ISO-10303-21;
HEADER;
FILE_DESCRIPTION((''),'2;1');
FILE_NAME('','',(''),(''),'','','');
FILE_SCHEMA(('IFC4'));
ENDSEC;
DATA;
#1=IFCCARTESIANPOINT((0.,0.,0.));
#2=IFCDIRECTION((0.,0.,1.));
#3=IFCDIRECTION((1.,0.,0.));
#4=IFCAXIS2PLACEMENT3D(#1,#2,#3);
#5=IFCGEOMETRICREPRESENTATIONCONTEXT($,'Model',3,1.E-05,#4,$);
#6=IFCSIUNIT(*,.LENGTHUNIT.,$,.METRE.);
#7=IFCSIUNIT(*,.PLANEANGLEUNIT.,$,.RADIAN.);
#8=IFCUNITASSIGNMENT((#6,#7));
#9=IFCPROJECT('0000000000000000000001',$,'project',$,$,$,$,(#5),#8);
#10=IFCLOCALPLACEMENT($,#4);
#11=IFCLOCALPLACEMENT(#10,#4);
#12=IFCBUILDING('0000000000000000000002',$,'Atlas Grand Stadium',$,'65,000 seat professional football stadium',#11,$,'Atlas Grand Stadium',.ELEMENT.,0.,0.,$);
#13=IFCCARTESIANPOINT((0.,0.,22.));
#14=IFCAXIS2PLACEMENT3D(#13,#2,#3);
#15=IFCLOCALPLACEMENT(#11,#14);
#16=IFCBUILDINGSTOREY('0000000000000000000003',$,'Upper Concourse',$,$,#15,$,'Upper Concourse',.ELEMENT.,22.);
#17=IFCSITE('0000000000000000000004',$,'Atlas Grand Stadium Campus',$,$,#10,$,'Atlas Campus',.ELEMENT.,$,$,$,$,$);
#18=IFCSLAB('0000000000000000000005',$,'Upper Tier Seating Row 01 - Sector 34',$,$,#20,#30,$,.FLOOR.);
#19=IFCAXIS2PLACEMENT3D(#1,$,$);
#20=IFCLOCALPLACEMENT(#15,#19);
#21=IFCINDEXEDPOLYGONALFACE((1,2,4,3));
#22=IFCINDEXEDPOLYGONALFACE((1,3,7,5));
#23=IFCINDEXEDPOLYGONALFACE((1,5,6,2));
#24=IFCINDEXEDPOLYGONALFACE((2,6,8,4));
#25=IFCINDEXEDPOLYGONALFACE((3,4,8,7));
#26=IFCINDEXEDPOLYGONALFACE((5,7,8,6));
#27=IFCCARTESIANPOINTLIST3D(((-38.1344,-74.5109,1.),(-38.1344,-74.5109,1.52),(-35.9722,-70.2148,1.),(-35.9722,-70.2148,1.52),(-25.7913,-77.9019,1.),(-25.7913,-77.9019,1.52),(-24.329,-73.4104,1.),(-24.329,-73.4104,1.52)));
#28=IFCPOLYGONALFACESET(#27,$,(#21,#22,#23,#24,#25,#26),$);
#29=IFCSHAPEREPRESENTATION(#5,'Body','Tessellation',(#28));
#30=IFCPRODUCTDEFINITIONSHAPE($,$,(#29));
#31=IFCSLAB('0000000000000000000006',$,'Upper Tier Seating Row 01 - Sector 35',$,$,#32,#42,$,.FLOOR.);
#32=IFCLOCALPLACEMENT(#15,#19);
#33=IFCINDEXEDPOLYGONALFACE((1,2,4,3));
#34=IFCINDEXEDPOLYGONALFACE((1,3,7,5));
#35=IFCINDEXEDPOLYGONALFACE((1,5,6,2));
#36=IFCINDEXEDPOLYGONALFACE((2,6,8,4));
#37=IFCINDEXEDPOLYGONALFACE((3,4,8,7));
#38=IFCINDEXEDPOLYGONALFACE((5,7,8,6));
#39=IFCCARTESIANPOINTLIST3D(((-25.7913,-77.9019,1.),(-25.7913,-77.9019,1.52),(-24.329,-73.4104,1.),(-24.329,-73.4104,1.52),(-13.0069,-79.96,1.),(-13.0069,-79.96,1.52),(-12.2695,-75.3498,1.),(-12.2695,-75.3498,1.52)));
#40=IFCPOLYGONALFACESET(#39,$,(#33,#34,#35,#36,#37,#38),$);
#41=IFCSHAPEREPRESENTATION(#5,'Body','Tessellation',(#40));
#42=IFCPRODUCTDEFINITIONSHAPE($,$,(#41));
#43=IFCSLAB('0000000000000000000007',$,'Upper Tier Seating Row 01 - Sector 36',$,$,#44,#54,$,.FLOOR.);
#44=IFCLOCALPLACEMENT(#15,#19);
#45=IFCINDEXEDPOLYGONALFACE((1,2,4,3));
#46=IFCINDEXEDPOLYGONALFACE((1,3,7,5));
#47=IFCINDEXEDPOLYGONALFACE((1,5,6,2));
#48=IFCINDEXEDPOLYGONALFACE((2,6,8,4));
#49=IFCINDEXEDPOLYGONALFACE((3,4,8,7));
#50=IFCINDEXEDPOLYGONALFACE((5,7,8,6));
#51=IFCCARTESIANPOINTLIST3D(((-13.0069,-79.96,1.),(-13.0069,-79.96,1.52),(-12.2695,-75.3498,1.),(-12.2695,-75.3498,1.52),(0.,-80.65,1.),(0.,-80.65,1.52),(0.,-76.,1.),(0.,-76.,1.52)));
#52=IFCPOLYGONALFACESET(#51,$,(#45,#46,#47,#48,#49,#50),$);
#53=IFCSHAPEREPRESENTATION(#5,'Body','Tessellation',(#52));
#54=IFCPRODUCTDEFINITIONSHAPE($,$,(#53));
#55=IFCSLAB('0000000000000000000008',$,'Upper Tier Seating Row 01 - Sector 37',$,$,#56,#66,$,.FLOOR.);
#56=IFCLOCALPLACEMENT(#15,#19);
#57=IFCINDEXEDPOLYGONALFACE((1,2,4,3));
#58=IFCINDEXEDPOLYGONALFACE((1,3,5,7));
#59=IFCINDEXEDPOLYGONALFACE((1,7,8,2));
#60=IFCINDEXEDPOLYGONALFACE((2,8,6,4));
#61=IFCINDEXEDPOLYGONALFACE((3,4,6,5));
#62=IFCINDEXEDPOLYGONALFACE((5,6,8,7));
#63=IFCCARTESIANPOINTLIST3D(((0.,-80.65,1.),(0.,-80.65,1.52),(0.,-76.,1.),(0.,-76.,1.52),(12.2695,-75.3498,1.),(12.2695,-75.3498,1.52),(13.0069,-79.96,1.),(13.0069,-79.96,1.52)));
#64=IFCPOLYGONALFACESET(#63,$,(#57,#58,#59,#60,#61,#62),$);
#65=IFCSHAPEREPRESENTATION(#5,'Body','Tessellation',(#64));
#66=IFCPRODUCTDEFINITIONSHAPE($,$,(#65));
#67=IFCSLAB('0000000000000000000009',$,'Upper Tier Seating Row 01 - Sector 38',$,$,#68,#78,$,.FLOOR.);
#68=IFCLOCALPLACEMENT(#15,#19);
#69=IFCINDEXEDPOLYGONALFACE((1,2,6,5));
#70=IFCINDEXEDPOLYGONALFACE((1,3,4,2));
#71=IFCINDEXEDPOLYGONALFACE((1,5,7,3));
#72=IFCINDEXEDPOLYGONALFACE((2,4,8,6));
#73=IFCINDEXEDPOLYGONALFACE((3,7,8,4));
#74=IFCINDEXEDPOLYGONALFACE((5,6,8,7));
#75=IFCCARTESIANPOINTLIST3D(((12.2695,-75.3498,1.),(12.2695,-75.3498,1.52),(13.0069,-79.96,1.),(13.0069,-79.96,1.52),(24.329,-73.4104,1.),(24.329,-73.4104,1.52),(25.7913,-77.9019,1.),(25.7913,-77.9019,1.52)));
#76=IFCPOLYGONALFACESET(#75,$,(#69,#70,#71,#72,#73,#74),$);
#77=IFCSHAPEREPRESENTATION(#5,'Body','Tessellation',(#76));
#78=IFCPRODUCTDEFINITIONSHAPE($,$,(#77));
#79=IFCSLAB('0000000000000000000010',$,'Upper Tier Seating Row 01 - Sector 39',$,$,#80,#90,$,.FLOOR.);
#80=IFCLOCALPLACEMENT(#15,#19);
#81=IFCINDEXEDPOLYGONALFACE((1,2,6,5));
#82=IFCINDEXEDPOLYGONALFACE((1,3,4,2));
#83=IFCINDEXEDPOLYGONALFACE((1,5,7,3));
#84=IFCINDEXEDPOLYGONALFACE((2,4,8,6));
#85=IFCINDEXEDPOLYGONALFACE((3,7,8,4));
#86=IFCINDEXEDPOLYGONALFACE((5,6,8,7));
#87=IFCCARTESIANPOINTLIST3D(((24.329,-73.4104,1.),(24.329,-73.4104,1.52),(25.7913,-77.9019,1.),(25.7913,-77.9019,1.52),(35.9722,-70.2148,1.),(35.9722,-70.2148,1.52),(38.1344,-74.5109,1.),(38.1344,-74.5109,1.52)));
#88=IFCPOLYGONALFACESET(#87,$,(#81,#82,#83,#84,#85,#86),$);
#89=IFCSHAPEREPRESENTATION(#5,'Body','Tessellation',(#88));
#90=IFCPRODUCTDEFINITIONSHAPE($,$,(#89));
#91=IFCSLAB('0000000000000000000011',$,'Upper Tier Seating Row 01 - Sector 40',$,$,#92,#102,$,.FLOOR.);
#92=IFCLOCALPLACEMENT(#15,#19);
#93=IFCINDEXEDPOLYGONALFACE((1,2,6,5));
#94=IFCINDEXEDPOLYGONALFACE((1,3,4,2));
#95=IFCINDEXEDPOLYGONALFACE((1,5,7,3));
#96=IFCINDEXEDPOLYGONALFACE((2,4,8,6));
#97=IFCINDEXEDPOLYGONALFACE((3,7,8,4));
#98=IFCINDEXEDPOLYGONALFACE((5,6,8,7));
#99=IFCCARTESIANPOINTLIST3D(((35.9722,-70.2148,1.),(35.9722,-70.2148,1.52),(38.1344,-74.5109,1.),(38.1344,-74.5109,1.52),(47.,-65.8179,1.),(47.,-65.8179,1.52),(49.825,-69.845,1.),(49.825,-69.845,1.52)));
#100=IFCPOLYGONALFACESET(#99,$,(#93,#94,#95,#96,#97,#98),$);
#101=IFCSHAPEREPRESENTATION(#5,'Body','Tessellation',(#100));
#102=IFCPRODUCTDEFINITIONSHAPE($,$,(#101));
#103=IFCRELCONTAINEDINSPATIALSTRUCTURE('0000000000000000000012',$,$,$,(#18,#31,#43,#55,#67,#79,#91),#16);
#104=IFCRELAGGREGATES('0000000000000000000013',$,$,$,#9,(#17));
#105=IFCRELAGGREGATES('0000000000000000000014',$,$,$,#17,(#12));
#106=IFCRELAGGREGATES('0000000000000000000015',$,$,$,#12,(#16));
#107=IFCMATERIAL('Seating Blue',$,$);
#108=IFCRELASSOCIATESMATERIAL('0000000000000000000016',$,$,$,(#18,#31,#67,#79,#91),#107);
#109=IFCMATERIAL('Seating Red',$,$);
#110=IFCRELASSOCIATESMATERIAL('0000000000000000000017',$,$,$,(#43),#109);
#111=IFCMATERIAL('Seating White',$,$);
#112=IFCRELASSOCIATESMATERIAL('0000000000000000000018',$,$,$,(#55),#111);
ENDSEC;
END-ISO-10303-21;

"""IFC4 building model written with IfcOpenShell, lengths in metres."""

from ifc_helpers import new_model, si_unit, frame, origin_with_axes, place, context, project, spatial, polyline, outline, extrude, material, element, save


model = new_model("IFC4")

# Units and contexts
model_context = context("Model", 3, precision=1e-05, world=origin_with_axes())
ifc_project = project(units=[si_unit("LENGTHUNIT", "METRE"), si_unit("PLANEANGLEUNIT", "RADIAN")], contexts=[model_context])

# Site, building, storey
site_placement = place(None, origin_with_axes())
site = spatial("IfcSite", under=ifc_project, at=site_placement, Name="Atlas Grand Stadium Campus", LongName="Atlas Campus", CompositionType="ELEMENT")
building_placement = place(site_placement, origin_with_axes())
building = spatial("IfcBuilding", under=site, at=building_placement, Name="Atlas Grand Stadium", ObjectType="65,000 seat professional football stadium", LongName="Atlas Grand Stadium", CompositionType="ELEMENT", ElevationOfRefHeight=0.0, ElevationOfTerrain=0.0)
storey_placement = place(building_placement, frame((0.0, 0.0, 22.0), z_axis=(0.0, 0.0, 1.0), x_axis=(1.0, 0.0, 0.0)))
storey = spatial("IfcBuildingStorey", under=building, at=storey_placement, Name="Upper Concourse", LongName="Upper Concourse", CompositionType="ELEMENT", Elevation=22.0)

# Slabs
ifc_material_1 = material(Name="Seating Blue")
ifc_material_2 = material(Name="Seating White")
ifc_material_3 = material(Name="Seating Red")
slab_1_placement = place(storey_placement, frame((0.0, 0.0, 1.0), z_axis=(0.0, 0.0, 1.0), x_axis=(1.0, 0.0, 0.0)))
element("IfcSlab", 1, at=slab_1_placement, inside=storey, material=ifc_material_1, Name="Upper Tier Seating Row 01 - Sector 34", PredefinedType="FLOOR", context=model_context, shape_type="SweptSolid", body=[
    extrude(outline(polyline([(-38.1344, -74.5109), (-25.7913, -77.9019), (-24.329, -73.4104), (-35.9722, -70.2148), (-38.1344, -74.5109)])), origin_with_axes(), (0.0, 0.0, 1.0), 0.52),
])
slab_2_placement = place(storey_placement, frame((0.0, 0.0, 1.0), z_axis=(0.0, 0.0, 1.0), x_axis=(1.0, 0.0, 0.0)))
element("IfcSlab", 2, at=slab_2_placement, inside=storey, material=ifc_material_1, Name="Upper Tier Seating Row 01 - Sector 35", PredefinedType="FLOOR", context=model_context, shape_type="SweptSolid", body=[
    extrude(outline(polyline([(-25.7913, -77.9019), (-13.0069, -79.96), (-12.2695, -75.3498), (-24.329, -73.4104), (-25.7913, -77.9019)])), origin_with_axes(), (0.0, 0.0, 1.0), 0.52),
])
slab_3_placement = place(storey_placement, frame((0.0, 0.0, 1.0), z_axis=(0.0, 0.0, 1.0), x_axis=(1.0, 0.0, 0.0)))
element("IfcSlab", 3, at=slab_3_placement, inside=storey, material=ifc_material_3, Name="Upper Tier Seating Row 01 - Sector 36", PredefinedType="FLOOR", context=model_context, shape_type="SweptSolid", body=[
    extrude(outline(polyline([(-13.0069, -79.96), (0.0, -80.65), (0.0, -76.0), (-12.2695, -75.3498), (-13.0069, -79.96)])), origin_with_axes(), (0.0, 0.0, 1.0), 0.52),
])
slab_4_placement = place(storey_placement, frame((0.0, 0.0, 1.0), z_axis=(0.0, 0.0, 1.0), x_axis=(1.0, 0.0, 0.0)))
element("IfcSlab", 4, at=slab_4_placement, inside=storey, material=ifc_material_2, Name="Upper Tier Seating Row 01 - Sector 37", PredefinedType="FLOOR", context=model_context, shape_type="SweptSolid", body=[
    extrude(outline(polyline([(0.0, -80.65), (13.0069, -79.96), (12.2695, -75.3498), (0.0, -76.0), (0.0, -80.65)])), origin_with_axes(), (0.0, 0.0, 1.0), 0.52),
])
slab_5_placement = place(storey_placement, frame((0.0, 0.0, 1.0), z_axis=(0.0, 0.0, 1.0), x_axis=(1.0, 0.0, 0.0)))
element("IfcSlab", 5, at=slab_5_placement, inside=storey, material=ifc_material_1, Name="Upper Tier Seating Row 01 - Sector 38", PredefinedType="FLOOR", context=model_context, shape_type="SweptSolid", body=[
    extrude(outline(polyline([(13.0069, -79.96), (25.7913, -77.9019), (24.329, -73.4104), (12.2695, -75.3498), (13.0069, -79.96)])), origin_with_axes(), (0.0, 0.0, 1.0), 0.52),
])
slab_6_placement = place(storey_placement, frame((0.0, 0.0, 1.0), z_axis=(0.0, 0.0, 1.0), x_axis=(1.0, 0.0, 0.0)))
element("IfcSlab", 6, at=slab_6_placement, inside=storey, material=ifc_material_1, Name="Upper Tier Seating Row 01 - Sector 39", PredefinedType="FLOOR", context=model_context, shape_type="SweptSolid", body=[
    extrude(outline(polyline([(25.7913, -77.9019), (38.1344, -74.5109), (35.9722, -70.2148), (24.329, -73.4104), (25.7913, -77.9019)])), origin_with_axes(), (0.0, 0.0, 1.0), 0.52),
])
slab_7_placement = place(storey_placement, frame((0.0, 0.0, 1.0), z_axis=(0.0, 0.0, 1.0), x_axis=(1.0, 0.0, 0.0)))
element("IfcSlab", 7, at=slab_7_placement, inside=storey, material=ifc_material_1, Name="Upper Tier Seating Row 01 - Sector 40", PredefinedType="FLOOR", context=model_context, shape_type="SweptSolid", body=[
    extrude(outline(polyline([(38.1344, -74.5109), (49.825, -69.8449), (47.0, -65.8179), (35.9722, -70.2148), (38.1344, -74.5109)])), origin_with_axes(), (0.0, 0.0, 1.0), 0.52),
])

save(model, "model.ifc")
